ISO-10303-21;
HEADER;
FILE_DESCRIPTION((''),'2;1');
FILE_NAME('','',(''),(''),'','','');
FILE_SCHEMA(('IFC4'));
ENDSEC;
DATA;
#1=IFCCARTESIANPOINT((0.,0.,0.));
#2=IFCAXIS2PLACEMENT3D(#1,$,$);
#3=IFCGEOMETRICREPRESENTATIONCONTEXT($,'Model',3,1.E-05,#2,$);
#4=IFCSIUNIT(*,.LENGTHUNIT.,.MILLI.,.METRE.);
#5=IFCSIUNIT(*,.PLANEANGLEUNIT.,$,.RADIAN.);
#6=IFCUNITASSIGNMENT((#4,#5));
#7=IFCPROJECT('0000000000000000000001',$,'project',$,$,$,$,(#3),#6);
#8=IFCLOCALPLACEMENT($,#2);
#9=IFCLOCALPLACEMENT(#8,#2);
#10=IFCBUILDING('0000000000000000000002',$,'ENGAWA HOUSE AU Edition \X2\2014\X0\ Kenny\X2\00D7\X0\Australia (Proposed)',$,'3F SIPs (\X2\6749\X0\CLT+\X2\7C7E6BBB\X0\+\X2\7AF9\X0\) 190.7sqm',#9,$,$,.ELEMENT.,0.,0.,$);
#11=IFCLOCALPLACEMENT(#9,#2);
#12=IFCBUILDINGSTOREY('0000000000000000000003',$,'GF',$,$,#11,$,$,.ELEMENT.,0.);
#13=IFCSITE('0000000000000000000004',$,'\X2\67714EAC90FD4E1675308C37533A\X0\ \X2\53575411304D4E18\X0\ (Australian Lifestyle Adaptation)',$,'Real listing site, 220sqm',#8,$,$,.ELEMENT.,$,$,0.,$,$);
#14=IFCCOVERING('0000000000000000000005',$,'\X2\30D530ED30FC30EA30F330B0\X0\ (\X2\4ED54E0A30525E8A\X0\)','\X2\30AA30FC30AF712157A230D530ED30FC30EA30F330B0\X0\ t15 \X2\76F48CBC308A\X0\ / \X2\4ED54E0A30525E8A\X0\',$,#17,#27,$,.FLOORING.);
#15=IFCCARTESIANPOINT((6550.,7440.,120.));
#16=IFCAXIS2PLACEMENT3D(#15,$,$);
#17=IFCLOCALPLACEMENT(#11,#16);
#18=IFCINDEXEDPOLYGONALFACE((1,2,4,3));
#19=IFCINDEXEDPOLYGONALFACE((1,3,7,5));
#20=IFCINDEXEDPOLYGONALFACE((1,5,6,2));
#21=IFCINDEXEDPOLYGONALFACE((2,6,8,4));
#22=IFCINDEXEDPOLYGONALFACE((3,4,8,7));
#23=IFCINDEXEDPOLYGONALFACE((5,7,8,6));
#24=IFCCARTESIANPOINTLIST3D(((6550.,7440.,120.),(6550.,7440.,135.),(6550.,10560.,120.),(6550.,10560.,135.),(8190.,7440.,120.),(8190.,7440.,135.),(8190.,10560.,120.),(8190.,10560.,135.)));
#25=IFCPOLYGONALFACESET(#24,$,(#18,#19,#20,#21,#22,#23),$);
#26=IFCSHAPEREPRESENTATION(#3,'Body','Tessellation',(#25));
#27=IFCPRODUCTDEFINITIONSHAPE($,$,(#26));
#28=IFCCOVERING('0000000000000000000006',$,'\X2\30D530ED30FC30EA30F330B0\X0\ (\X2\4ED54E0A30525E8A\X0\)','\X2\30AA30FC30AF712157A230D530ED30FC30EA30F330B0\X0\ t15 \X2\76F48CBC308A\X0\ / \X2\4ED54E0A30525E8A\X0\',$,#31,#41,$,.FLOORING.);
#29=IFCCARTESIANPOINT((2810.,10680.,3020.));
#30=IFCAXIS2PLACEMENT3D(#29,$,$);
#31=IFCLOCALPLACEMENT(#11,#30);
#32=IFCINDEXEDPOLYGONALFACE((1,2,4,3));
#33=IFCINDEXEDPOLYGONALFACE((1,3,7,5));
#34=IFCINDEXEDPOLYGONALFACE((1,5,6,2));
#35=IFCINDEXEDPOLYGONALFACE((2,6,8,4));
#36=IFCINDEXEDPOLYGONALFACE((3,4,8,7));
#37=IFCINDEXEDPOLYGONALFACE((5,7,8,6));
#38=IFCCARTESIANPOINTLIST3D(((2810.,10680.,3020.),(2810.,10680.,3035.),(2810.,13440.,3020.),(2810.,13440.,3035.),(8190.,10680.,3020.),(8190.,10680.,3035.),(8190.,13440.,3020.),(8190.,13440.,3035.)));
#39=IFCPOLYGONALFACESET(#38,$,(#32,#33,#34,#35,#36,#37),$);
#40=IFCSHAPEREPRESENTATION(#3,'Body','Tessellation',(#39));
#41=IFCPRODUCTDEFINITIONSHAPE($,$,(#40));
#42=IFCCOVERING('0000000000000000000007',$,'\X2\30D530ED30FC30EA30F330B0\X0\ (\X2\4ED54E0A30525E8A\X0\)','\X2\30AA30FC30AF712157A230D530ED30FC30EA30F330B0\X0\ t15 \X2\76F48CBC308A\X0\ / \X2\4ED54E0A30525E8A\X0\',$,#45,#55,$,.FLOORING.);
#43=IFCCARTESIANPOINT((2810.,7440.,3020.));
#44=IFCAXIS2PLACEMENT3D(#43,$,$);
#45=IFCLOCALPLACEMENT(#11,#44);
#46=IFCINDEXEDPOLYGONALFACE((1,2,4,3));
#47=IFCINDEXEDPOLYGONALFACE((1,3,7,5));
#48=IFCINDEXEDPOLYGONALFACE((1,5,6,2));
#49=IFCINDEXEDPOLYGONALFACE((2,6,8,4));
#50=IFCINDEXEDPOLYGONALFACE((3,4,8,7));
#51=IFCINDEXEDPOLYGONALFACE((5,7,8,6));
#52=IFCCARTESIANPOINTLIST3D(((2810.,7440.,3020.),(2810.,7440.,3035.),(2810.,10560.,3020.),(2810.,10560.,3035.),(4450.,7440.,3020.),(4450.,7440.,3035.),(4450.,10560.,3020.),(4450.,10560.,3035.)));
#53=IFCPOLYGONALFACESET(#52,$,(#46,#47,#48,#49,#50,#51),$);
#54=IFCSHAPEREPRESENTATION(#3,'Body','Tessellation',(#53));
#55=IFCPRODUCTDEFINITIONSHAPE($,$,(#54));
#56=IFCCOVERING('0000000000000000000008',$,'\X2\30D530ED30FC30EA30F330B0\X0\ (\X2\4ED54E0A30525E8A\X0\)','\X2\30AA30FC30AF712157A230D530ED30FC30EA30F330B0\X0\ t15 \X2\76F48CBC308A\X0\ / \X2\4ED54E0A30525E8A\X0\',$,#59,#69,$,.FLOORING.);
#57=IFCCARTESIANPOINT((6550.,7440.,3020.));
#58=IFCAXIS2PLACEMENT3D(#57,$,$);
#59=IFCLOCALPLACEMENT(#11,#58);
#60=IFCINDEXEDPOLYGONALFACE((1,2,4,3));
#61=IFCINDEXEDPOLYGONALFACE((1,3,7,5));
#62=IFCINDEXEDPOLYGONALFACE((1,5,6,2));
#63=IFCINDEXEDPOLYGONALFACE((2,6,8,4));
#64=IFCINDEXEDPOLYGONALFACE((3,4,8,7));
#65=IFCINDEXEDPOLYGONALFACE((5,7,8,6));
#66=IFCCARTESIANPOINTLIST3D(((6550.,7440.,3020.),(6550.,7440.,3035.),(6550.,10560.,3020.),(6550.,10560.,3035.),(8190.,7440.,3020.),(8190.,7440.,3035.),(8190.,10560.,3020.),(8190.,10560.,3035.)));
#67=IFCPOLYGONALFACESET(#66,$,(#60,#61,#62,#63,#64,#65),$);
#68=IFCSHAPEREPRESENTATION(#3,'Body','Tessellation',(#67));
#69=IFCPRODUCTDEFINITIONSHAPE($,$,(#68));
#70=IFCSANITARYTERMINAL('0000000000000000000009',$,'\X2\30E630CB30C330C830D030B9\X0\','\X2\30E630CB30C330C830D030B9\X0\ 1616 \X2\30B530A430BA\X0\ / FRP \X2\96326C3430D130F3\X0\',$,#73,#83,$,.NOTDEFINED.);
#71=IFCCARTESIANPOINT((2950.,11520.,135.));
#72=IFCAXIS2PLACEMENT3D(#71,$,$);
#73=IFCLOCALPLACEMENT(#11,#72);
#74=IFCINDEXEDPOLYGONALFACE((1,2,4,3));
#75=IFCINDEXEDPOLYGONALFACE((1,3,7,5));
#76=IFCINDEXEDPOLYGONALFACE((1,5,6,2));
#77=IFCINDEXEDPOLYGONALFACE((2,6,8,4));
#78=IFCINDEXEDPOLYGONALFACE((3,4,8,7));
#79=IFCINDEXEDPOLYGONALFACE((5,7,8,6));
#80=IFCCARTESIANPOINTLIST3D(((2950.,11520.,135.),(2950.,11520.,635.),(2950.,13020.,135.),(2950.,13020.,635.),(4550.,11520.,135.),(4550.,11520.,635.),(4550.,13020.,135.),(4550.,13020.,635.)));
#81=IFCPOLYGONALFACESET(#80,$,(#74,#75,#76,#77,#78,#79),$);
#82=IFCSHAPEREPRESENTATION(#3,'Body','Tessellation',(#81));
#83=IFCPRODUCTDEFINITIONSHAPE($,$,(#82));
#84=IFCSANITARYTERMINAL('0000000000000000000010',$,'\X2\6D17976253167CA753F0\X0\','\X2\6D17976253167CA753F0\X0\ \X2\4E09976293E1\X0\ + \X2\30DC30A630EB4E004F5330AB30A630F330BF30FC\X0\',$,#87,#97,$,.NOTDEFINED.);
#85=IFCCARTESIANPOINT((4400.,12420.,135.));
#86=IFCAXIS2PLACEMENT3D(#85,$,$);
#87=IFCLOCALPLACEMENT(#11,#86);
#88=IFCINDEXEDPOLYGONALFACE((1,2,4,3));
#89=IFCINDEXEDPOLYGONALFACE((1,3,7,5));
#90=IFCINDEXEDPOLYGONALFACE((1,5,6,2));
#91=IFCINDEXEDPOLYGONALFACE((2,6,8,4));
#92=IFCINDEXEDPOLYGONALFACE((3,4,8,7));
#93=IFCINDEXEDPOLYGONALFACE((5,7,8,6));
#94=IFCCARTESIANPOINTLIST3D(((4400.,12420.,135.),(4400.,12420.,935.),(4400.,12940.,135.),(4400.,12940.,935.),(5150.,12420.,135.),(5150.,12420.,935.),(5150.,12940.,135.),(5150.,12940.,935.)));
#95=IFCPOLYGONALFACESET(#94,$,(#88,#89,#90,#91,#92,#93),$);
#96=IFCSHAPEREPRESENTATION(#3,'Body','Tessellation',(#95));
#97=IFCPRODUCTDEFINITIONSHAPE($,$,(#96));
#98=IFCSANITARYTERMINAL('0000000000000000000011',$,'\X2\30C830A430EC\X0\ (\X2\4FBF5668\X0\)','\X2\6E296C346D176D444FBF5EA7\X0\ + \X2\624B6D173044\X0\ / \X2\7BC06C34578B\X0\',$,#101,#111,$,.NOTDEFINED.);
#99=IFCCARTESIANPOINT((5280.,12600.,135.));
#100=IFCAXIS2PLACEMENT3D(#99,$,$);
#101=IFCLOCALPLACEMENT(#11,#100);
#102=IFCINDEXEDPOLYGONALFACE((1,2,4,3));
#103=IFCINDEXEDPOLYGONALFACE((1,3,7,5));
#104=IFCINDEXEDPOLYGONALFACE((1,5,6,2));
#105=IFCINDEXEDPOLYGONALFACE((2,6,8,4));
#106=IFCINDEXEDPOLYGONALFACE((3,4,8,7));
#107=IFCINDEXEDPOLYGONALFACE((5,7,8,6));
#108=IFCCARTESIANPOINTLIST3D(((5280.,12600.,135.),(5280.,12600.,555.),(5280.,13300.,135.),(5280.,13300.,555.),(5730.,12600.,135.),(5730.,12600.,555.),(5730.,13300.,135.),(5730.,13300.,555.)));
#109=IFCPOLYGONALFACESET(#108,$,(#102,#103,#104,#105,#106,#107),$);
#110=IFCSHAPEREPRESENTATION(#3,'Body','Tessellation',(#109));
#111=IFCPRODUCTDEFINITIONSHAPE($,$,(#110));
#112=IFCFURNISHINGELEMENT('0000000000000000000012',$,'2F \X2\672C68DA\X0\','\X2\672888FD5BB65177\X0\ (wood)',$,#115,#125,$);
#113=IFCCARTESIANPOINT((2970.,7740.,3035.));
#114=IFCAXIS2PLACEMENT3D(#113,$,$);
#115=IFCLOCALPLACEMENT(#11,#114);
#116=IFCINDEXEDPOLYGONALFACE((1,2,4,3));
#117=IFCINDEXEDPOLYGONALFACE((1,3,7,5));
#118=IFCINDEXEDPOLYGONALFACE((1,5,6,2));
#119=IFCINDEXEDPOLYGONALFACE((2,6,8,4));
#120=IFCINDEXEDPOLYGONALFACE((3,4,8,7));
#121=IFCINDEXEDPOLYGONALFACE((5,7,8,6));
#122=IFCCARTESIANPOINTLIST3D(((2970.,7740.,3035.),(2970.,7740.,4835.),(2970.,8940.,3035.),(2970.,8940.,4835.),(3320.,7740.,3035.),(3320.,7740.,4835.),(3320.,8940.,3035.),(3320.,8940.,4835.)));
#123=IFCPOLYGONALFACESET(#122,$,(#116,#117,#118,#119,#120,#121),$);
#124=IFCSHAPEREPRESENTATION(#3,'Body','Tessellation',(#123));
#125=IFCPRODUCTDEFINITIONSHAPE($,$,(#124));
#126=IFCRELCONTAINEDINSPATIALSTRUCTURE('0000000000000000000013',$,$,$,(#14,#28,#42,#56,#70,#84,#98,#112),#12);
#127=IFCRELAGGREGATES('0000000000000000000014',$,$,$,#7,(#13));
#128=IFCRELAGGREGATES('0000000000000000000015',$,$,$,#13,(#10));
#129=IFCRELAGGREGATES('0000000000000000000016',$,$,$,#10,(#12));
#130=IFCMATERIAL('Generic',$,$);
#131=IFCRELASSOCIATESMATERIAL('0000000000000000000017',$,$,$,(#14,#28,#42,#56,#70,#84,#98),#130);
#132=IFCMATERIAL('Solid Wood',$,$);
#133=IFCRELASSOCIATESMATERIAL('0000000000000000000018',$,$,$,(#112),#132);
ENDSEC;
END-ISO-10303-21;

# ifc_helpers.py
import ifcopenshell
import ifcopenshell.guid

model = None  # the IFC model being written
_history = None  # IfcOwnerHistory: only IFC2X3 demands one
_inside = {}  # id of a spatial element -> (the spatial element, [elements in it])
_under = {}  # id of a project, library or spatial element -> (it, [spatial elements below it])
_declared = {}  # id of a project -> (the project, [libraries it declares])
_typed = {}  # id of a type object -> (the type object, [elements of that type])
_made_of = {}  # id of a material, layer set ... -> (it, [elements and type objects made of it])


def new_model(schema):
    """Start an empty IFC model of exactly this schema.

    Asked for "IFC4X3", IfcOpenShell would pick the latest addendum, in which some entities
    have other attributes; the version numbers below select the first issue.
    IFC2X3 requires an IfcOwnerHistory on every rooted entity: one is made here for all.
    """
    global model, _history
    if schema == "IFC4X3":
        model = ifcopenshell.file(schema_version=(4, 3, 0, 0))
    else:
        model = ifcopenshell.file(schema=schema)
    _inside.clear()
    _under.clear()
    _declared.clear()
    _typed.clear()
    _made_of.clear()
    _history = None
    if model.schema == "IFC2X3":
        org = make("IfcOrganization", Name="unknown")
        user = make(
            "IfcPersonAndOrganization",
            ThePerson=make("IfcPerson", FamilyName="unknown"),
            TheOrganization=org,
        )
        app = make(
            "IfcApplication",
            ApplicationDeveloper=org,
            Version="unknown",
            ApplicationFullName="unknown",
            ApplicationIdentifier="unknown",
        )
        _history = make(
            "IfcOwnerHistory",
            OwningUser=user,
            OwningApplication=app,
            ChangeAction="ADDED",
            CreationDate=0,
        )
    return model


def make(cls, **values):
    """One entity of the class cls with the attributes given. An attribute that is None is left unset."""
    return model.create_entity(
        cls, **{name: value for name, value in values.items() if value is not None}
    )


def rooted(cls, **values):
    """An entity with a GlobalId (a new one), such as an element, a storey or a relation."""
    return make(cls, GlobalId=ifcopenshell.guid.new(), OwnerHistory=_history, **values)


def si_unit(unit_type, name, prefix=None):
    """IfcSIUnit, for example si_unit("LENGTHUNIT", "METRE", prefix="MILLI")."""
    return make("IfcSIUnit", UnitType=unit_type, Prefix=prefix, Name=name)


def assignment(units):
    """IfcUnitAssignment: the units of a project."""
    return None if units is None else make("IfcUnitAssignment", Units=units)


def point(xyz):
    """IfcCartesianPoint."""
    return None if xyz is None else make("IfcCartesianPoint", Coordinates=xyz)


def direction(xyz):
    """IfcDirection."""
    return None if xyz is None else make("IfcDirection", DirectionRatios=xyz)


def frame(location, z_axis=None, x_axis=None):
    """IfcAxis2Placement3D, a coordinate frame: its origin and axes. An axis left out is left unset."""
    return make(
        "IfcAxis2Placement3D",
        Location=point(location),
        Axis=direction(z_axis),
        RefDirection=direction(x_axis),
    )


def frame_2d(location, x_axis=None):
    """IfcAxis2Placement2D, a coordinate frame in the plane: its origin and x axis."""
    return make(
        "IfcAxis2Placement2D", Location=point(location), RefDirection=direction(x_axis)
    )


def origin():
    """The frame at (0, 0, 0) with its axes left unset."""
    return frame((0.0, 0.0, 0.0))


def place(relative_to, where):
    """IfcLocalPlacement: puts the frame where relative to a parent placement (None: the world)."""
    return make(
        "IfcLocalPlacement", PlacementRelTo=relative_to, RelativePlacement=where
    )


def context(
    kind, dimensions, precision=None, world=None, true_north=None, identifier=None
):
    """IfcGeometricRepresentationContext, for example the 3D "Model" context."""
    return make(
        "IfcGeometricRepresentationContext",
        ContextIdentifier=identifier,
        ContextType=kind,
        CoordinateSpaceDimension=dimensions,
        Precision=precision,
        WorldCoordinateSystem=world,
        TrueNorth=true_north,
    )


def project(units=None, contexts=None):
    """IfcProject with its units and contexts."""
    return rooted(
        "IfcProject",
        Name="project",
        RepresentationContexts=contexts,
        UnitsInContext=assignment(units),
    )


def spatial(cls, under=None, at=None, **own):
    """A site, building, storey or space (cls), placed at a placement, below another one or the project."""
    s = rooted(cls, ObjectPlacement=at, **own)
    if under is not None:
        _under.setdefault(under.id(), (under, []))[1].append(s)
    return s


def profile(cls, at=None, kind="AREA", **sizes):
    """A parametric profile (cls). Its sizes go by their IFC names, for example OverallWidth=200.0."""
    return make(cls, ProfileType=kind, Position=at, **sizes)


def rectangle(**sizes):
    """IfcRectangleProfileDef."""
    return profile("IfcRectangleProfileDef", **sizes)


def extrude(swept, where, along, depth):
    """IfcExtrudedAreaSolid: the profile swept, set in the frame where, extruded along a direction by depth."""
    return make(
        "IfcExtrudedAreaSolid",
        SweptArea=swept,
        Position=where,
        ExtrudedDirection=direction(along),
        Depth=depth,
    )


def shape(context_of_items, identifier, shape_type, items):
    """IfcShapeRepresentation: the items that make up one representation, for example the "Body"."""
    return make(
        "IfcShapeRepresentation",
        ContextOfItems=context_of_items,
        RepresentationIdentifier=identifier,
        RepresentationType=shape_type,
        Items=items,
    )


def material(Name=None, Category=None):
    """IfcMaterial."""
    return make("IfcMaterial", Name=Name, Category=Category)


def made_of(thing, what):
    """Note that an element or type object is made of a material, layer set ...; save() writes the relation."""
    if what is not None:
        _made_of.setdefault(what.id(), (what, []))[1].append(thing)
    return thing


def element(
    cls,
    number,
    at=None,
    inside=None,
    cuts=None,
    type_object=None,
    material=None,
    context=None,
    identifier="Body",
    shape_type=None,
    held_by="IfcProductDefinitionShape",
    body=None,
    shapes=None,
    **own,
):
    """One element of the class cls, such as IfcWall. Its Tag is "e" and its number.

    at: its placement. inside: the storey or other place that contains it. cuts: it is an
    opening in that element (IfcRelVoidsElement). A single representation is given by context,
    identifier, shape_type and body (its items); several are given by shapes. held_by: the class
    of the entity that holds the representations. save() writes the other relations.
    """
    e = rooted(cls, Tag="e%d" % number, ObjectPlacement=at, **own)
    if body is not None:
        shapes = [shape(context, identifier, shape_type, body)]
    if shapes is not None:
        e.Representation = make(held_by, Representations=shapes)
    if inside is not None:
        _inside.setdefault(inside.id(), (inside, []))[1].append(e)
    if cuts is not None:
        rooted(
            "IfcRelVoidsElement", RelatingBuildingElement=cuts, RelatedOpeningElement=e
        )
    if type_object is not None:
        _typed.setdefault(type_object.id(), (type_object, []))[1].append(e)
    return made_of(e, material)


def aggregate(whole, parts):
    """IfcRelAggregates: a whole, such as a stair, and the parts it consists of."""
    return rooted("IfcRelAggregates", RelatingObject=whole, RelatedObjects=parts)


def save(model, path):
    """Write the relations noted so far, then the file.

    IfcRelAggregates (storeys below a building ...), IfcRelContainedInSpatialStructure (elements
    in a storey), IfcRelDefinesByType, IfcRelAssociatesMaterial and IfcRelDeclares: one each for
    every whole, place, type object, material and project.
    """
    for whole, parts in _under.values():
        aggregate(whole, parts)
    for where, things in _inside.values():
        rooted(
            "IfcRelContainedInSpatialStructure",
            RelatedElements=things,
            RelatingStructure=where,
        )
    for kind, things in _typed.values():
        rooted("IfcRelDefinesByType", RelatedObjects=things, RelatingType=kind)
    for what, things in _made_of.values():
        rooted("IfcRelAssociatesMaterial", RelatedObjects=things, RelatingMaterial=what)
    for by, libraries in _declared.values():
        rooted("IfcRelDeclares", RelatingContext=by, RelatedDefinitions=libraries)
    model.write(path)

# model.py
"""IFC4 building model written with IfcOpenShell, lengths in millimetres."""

from ifc_helpers import new_model, si_unit, frame, frame_2d, origin, place, context, project, spatial, rectangle, extrude, material, element, save


model = new_model("IFC4")

# Units and contexts
model_context = context("Model", 3, precision=1e-05, world=origin())
ifc_project = project(units=[si_unit("LENGTHUNIT", "METRE", prefix="MILLI"), si_unit("PLANEANGLEUNIT", "RADIAN")], contexts=[model_context])

# Site, building, storey
site_placement = place(None, origin())
site = spatial("IfcSite", under=ifc_project, at=site_placement, Name="東京都世田谷区 南向き丘 (Australian Lifestyle Adaptation)", ObjectType="Real listing site, 220sqm", CompositionType="ELEMENT", RefElevation=0.0)
building_placement = place(site_placement, origin())
building = spatial("IfcBuilding", under=site, at=building_placement, Name="ENGAWA HOUSE AU Edition — Kenny×Australia (Proposed)", ObjectType="3F SIPs (杉CLT+籾殻+竹) 190.7sqm", CompositionType="ELEMENT", ElevationOfRefHeight=0.0, ElevationOfTerrain=0.0)
storey_placement = place(building_placement, origin())
storey = spatial("IfcBuildingStorey", under=building, at=storey_placement, Name="GF", CompositionType="ELEMENT", Elevation=0.0)

# Shared definitions
ifc_material_1 = material(Name="Solid Wood")

# Coverings
ifc_material_2 = material(Name="Generic")
covering_1_placement = place(storey_placement, frame((6550.0, 7440.0, 120.0)))
element("IfcCovering", 1, at=covering_1_placement, inside=storey, material=ifc_material_2, Name="フローリング (仕上げ床)", Description="オーク無垢フローリング t15 直貼り / 仕上げ床", PredefinedType="FLOORING", context=model_context, shape_type="SweptSolid", body=[
    extrude(rectangle(XDim=1640.0, YDim=3120.0, at=frame_2d((820.0, 1560.0))), frame((6550.0, 7440.0, 120.0)), (0.0, 0.0, 1.0), 15.0),
])
covering_2_placement = place(storey_placement, frame((2810.0, 10680.0, 3020.0)))
element("IfcCovering", 2, at=covering_2_placement, inside=storey, material=ifc_material_2, Name="フローリング (仕上げ床)", Description="オーク無垢フローリング t15 直貼り / 仕上げ床", PredefinedType="FLOORING", context=model_context, shape_type="SweptSolid", body=[
    extrude(rectangle(XDim=5380.0, YDim=2760.0, at=frame_2d((2690.0, 1380.0))), frame((2810.0, 10680.0, 3020.0)), (0.0, 0.0, 1.0), 15.0),
])
covering_3_placement = place(storey_placement, frame((2810.0, 7440.0, 3020.0)))
element("IfcCovering", 3, at=covering_3_placement, inside=storey, material=ifc_material_2, Name="フローリング (仕上げ床)", Description="オーク無垢フローリング t15 直貼り / 仕上げ床", PredefinedType="FLOORING", context=model_context, shape_type="SweptSolid", body=[
    extrude(rectangle(XDim=1640.0, YDim=3120.0, at=frame_2d((820.0, 1560.0))), frame((2810.0, 7440.0, 3020.0)), (0.0, 0.0, 1.0), 15.0),
])
covering_4_placement = place(storey_placement, frame((6550.0, 7440.0, 3020.0)))
element("IfcCovering", 4, at=covering_4_placement, inside=storey, material=ifc_material_2, Name="フローリング (仕上げ床)", Description="オーク無垢フローリング t15 直貼り / 仕上げ床", PredefinedType="FLOORING", context=model_context, shape_type="SweptSolid", body=[
    extrude(rectangle(XDim=1640.0, YDim=3120.0, at=frame_2d((820.0, 1560.0))), frame((6550.0, 7440.0, 3020.0)), (0.0, 0.0, 1.0), 15.0),
])

# Sanitary terminals
sanitary_terminal_1_placement = place(storey_placement, frame((2950.0, 11520.0, 135.0)))
element("IfcSanitaryTerminal", 5, at=sanitary_terminal_1_placement, inside=storey, material=ifc_material_2, Name="ユニットバス", Description="ユニットバス 1616 サイズ / FRP 防水パン", PredefinedType="NOTDEFINED", context=model_context, shape_type="SweptSolid", body=[
    extrude(rectangle(XDim=1600.0, YDim=1500.0, at=frame_2d((800.0, 750.0))), frame((2950.0, 11520.0, 135.0)), (0.0, 0.0, 1.0), 500.0),
])
sanitary_terminal_2_placement = place(storey_placement, frame((4400.0, 12420.0, 135.0)))
element("IfcSanitaryTerminal", 6, at=sanitary_terminal_2_placement, inside=storey, material=ifc_material_2, Name="洗面化粧台", Description="洗面化粧台 三面鏡 + ボウル一体カウンター", PredefinedType="NOTDEFINED", context=model_context, shape_type="SweptSolid", body=[
    extrude(rectangle(XDim=750.0, YDim=520.0, at=frame_2d((375.0, 260.0))), frame((4400.0, 12420.0, 135.0)), (0.0, 0.0, 1.0), 800.0),
])
sanitary_terminal_3_placement = place(storey_placement, frame((5280.0, 12600.0, 135.0)))
element("IfcSanitaryTerminal", 7, at=sanitary_terminal_3_placement, inside=storey, material=ifc_material_2, Name="トイレ (便器)", Description="温水洗浄便座 + 手洗い / 節水型", PredefinedType="NOTDEFINED", context=model_context, shape_type="SweptSolid", body=[
    extrude(rectangle(XDim=450.0, YDim=700.0, at=frame_2d((225.0, 350.0))), frame((5280.0, 12600.0, 135.0)), (0.0, 0.0, 1.0), 420.0),
])

# Furnishing element
furnishing_placement = place(storey_placement, frame((2970.0, 7740.0, 3035.0)))
element("IfcFurnishingElement", 8, at=furnishing_placement, inside=storey, material=ifc_material_1, Name="2F 本棚", Description="木製家具 (wood)", context=model_context, shape_type="SweptSolid", body=[
    extrude(rectangle(XDim=350.0, YDim=1200.0, at=frame_2d((175.0, 600.0))), frame((2970.0, 7740.0, 3035.0)), (0.0, 0.0, 1.0), 1800.0),
])

save(model, "model.ifc")
